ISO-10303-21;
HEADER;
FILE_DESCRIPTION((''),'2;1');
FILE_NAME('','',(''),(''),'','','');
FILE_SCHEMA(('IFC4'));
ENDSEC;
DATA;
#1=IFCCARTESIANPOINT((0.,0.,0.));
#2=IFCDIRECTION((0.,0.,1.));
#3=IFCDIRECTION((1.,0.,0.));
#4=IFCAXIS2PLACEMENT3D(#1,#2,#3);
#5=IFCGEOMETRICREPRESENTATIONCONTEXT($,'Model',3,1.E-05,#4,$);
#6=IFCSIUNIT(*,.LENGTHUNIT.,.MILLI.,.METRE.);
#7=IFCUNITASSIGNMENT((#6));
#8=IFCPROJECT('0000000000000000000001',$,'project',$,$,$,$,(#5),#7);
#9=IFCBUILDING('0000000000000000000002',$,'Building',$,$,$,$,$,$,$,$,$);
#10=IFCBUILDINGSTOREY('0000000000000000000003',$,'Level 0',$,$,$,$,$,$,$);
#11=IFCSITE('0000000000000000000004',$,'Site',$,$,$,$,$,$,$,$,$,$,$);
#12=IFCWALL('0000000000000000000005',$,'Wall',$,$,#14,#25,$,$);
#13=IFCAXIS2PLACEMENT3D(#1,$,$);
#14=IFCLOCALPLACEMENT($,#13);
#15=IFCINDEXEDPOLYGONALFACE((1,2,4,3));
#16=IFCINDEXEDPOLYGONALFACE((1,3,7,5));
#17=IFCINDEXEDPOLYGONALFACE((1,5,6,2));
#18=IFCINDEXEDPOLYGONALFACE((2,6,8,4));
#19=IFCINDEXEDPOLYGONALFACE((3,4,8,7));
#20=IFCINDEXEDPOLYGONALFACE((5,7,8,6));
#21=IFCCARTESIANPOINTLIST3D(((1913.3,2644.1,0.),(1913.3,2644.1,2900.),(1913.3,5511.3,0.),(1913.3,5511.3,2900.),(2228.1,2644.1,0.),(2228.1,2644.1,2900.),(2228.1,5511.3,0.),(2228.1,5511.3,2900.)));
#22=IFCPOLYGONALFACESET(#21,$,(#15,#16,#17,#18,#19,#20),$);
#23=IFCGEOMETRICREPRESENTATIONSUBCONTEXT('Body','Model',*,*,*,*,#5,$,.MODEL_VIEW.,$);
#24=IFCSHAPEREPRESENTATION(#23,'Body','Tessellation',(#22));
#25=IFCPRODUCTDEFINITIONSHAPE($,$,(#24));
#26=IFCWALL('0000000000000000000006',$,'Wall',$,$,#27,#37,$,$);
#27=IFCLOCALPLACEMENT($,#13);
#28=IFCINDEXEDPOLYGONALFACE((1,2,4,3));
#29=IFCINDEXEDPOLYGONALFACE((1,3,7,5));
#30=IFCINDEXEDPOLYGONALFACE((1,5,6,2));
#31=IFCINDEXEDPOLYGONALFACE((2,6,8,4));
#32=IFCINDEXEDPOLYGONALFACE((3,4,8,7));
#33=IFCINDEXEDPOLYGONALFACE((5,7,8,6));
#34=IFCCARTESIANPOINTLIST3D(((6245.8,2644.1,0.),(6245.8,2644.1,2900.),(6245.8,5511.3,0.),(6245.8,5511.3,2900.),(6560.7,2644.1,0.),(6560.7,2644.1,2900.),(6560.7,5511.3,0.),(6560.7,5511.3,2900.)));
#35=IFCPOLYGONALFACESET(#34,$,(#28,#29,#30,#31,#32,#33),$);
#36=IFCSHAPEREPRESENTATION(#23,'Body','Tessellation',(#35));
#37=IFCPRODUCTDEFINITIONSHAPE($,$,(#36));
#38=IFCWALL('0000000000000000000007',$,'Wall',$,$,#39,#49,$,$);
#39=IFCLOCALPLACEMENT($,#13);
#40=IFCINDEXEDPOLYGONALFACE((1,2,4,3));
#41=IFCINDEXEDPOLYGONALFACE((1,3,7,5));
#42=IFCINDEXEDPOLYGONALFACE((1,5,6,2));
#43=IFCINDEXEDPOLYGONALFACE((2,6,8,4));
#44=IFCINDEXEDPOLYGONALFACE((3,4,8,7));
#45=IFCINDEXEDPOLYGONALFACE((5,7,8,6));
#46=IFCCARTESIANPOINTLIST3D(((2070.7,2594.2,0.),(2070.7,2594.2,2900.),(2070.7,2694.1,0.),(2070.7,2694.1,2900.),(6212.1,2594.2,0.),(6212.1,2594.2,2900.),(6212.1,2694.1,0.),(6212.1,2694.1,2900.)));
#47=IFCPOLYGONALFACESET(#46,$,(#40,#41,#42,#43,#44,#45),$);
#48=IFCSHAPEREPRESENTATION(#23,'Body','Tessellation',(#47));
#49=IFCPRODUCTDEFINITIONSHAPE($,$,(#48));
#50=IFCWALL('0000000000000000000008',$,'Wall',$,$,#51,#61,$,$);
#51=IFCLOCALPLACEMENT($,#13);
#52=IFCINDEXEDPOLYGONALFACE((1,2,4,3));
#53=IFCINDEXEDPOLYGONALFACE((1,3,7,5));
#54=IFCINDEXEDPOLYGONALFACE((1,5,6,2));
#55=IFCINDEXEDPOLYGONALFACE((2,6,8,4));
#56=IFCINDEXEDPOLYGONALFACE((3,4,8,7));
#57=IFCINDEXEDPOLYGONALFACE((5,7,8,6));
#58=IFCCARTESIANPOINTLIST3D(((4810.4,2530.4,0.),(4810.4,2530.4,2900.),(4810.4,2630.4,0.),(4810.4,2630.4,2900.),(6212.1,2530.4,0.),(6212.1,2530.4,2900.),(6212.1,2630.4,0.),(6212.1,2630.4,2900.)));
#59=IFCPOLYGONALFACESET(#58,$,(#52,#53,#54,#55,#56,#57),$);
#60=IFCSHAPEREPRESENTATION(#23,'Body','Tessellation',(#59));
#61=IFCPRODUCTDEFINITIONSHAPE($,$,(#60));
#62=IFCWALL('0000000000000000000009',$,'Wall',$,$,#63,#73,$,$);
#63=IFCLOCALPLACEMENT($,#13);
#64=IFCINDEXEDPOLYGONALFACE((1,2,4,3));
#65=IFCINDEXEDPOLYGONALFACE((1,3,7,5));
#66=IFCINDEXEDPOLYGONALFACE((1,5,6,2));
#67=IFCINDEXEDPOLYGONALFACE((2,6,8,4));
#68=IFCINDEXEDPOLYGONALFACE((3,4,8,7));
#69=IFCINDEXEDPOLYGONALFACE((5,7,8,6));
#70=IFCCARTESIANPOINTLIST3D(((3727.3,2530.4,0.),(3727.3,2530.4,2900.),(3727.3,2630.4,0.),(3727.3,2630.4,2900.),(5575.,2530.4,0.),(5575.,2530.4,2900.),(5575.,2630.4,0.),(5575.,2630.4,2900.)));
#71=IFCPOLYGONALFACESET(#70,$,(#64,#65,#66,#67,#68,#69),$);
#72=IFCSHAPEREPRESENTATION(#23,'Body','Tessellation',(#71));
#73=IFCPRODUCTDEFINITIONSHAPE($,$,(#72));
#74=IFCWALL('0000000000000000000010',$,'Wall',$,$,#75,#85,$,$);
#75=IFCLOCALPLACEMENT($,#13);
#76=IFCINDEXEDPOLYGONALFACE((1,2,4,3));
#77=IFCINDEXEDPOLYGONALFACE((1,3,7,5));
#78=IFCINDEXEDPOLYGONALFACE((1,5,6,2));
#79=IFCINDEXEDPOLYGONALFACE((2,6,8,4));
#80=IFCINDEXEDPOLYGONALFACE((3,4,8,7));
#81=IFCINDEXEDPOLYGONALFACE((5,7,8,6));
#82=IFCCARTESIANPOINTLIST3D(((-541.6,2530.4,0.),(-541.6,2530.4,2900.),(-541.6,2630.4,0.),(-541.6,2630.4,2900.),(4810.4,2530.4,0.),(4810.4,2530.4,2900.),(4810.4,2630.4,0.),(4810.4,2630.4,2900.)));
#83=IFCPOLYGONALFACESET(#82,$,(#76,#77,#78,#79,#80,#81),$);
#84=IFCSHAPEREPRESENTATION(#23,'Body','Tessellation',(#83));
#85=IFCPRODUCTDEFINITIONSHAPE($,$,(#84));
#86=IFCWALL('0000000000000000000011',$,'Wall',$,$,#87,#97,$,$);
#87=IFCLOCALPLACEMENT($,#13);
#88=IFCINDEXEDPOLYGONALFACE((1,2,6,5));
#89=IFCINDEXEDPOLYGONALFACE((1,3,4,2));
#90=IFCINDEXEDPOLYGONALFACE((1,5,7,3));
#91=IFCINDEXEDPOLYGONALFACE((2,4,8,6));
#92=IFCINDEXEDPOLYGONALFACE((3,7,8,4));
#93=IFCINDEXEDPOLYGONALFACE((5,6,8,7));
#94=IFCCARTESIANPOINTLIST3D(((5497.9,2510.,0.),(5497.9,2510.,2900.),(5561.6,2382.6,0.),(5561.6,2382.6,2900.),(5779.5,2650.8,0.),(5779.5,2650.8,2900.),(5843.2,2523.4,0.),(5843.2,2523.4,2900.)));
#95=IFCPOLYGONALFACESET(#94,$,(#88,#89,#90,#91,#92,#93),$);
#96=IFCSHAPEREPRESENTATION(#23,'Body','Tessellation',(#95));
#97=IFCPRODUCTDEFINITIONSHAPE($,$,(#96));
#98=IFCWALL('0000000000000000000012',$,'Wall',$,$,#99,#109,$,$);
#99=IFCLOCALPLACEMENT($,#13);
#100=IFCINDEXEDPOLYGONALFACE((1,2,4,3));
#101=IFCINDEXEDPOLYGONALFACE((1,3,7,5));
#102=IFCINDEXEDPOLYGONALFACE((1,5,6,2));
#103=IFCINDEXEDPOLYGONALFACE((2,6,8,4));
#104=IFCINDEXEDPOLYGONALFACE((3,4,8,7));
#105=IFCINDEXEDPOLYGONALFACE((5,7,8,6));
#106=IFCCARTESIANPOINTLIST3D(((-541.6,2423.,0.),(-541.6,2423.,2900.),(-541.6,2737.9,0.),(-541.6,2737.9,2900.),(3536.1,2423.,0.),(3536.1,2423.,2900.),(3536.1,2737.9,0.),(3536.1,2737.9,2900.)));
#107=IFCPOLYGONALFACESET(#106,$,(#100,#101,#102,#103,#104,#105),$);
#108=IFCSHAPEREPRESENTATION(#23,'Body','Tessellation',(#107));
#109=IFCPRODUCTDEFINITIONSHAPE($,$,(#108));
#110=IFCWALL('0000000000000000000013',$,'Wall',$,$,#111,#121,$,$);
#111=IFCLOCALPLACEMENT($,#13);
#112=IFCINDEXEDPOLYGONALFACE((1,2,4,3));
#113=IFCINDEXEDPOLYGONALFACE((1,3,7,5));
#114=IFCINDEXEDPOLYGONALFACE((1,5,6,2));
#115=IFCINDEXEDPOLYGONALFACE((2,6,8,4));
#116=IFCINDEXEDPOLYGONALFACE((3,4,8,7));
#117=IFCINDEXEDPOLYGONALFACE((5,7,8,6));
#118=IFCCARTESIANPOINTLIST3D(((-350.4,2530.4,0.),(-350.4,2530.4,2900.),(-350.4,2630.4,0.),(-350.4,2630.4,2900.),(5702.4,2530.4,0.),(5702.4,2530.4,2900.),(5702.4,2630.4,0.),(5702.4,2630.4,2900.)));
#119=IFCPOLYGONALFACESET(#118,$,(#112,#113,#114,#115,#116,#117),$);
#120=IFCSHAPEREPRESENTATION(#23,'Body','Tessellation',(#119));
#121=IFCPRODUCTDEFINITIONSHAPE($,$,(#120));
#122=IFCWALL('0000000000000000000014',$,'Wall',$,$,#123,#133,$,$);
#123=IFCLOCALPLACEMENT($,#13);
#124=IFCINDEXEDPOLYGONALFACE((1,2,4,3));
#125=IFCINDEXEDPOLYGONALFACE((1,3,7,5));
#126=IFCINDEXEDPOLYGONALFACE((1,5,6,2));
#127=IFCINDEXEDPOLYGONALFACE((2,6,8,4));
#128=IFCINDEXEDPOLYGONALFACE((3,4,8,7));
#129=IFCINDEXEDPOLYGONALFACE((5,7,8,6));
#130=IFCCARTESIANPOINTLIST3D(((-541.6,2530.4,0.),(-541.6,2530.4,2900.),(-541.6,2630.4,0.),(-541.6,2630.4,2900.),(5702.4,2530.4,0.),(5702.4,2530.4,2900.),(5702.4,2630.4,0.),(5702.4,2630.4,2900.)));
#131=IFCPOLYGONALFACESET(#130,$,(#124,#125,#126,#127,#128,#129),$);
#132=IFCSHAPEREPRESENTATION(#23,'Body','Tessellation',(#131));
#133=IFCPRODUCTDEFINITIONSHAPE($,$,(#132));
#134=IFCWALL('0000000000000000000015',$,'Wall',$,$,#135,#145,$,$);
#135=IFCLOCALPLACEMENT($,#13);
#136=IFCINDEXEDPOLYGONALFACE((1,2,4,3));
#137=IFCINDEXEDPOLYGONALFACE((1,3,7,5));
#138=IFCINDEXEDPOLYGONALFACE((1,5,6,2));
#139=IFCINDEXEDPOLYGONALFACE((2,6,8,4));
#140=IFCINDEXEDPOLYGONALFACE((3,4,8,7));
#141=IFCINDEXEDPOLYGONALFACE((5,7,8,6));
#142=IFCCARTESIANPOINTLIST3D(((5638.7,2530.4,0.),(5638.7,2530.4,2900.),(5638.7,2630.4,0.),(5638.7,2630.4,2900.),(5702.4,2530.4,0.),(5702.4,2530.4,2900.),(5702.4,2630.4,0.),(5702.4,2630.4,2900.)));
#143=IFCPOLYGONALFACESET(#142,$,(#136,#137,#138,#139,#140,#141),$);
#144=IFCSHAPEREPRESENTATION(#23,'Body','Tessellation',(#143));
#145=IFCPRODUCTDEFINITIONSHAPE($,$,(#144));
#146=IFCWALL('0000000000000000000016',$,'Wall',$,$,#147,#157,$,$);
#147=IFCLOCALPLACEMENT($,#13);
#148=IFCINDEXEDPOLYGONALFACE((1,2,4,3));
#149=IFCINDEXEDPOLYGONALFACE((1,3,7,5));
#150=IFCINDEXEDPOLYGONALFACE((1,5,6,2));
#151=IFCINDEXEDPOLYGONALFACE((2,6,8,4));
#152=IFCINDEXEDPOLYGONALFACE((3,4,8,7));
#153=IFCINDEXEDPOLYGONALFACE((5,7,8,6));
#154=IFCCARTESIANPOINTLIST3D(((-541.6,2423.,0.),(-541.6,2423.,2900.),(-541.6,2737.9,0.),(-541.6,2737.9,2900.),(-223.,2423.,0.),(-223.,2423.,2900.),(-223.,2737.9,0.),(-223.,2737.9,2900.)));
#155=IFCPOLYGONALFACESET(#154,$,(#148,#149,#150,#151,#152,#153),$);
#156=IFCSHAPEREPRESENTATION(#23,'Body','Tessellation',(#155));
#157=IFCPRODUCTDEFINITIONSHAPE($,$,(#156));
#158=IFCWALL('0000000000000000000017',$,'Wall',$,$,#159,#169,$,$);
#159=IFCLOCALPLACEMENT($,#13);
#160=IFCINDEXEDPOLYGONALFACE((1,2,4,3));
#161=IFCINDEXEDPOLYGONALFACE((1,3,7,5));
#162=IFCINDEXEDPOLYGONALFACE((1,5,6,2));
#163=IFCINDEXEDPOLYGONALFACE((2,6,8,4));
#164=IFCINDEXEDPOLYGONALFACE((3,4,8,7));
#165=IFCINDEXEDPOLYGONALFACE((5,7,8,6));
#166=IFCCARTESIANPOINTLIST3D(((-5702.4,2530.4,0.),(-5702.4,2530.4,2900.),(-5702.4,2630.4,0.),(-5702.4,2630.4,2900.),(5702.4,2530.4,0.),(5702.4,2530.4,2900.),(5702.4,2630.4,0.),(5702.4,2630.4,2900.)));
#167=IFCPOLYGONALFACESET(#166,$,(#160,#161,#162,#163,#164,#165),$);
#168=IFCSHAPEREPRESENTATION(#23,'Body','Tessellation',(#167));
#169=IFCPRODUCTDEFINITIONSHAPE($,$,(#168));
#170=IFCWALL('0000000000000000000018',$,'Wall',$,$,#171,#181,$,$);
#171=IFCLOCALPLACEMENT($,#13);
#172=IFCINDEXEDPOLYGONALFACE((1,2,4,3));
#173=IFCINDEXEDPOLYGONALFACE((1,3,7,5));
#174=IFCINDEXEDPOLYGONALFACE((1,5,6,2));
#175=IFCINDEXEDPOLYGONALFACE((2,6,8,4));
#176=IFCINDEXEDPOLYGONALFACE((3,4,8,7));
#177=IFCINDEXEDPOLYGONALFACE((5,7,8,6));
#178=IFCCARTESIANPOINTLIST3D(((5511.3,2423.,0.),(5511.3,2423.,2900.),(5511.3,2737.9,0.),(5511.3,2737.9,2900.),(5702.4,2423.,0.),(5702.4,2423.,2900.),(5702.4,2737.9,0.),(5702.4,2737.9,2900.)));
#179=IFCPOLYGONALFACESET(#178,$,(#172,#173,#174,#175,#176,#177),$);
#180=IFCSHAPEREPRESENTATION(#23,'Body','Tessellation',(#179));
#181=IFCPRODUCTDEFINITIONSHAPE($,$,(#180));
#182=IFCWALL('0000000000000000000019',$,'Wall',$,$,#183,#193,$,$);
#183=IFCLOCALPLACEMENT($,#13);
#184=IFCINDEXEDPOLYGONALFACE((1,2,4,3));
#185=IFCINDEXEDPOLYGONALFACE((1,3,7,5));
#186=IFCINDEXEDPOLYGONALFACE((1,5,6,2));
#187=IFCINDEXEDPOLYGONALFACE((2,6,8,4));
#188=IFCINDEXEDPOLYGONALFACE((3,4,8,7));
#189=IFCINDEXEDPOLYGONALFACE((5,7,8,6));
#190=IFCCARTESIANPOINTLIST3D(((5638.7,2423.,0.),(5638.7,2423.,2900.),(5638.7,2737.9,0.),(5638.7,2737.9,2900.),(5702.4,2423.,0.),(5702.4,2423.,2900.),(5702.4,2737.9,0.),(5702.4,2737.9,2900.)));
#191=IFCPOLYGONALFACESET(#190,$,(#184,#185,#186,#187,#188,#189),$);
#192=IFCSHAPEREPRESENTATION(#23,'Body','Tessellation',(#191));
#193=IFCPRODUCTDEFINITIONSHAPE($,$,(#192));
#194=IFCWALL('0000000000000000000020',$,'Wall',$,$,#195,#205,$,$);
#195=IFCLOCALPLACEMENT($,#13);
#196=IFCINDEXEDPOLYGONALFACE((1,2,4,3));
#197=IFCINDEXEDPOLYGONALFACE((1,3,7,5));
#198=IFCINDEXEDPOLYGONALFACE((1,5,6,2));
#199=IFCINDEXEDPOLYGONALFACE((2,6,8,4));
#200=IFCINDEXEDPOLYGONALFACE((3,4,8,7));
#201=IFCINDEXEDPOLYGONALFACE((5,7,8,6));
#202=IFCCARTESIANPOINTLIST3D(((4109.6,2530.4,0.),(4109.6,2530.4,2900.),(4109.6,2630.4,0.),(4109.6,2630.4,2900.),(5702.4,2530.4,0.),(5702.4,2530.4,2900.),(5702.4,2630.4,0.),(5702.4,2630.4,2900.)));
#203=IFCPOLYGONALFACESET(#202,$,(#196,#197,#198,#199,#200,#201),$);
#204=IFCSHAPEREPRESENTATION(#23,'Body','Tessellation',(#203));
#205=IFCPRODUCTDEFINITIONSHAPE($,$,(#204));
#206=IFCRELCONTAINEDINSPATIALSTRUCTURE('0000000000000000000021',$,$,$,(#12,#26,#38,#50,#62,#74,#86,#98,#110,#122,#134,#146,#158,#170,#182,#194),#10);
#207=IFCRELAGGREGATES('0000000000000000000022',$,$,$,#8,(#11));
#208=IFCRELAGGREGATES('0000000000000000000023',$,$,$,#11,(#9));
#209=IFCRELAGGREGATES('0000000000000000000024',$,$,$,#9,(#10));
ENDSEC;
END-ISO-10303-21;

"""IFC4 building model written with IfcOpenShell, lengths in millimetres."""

from ifc_helpers import new_model, si_unit, frame, origin_with_axes, place, context, subcontext, project, spatial, indexed_curve, outline, extrude, element, save


model = new_model("IFC4")

# Units and contexts
model_context = context("Model", 3, precision=1e-05, world=origin_with_axes())
body_context = subcontext(model_context, "Body", "Model", "MODEL_VIEW")
ifc_project = project(units=[si_unit("LENGTHUNIT", "METRE", prefix="MILLI")], contexts=[model_context])

# Site, building, storey
site = spatial("IfcSite", under=ifc_project, Name="Site")
building = spatial("IfcBuilding", under=site, Name="Building")
storey = spatial("IfcBuildingStorey", under=building, Name="Level 0")

# Walls
for number, where, z_axis, x_axis, name in (
    (1, (1913.3, 5511.3, 0.0), (0.0, 0.0, 1.0), (0.0, -1.0, 0.0), "Wall"),
    (2, (6245.8, 5511.3, 0.0), (0.0, 0.0, 1.0), (0.0, -1.0, 0.0), "Wall"),
):
    element("IfcWall", number, at=place(None, frame(where, z_axis=z_axis, x_axis=x_axis)), inside=storey, Name=name, context=body_context, shape_type="SweptSolid", body=[
        extrude(outline(indexed_curve([(0.0, 0.0), (0.0, 314.9), (2867.1, 314.9), (2867.1, 0.0), (0.0, 0.0)], self_intersect=False)), origin_with_axes(), (0.0, 0.0, 1.0), 2900.0),
    ])
wall_1_placement = place(None, frame((2070.7, 2594.2, 0.0), z_axis=(0.0, 0.0, 1.0), x_axis=(1.0, 0.0, 0.0)))
element("IfcWall", 3, at=wall_1_placement, inside=storey, Name="Wall", context=body_context, shape_type="SweptSolid", body=[
    extrude(outline(indexed_curve([(0.0, 0.0), (0.0, 99.9), (4141.4, 99.9), (4141.4, 0.0), (0.0, 0.0)], self_intersect=False)), origin_with_axes(), (0.0, 0.0, 1.0), 2900.0),
])
wall_2_placement = place(None, frame((4810.4, 2530.4, 0.0), z_axis=(0.0, 0.0, 1.0), x_axis=(1.0, 0.0, 0.0)))
element("IfcWall", 4, at=wall_2_placement, inside=storey, Name="Wall", context=body_context, shape_type="SweptSolid", body=[
    extrude(outline(indexed_curve([(0.0, 0.0), (0.0, 99.9), (1401.7, 99.9), (1401.7, 0.0), (0.0, 0.0)], self_intersect=False)), origin_with_axes(), (0.0, 0.0, 1.0), 2900.0),
])
wall_3_placement = place(None, frame((3727.3, 2530.4, 0.0), z_axis=(0.0, 0.0, 1.0), x_axis=(1.0, 0.0, 0.0)))
element("IfcWall", 5, at=wall_3_placement, inside=storey, Name="Wall", context=body_context, shape_type="SweptSolid", body=[
    extrude(outline(indexed_curve([(0.0, 0.0), (0.0, 99.9), (1847.7, 99.9), (1847.7, 0.0), (0.0, 0.0)], self_intersect=False)), origin_with_axes(), (0.0, 0.0, 1.0), 2900.0),
])
wall_4_placement = place(None, frame((4810.4, 2630.4, 0.0), z_axis=(0.0, 0.0, 1.0), x_axis=(-1.0, 0.0, 0.0)))
element("IfcWall", 6, at=wall_4_placement, inside=storey, Name="Wall", context=body_context, shape_type="SweptSolid", body=[
    extrude(outline(indexed_curve([(0.0, 0.0), (0.0, 99.9), (5352.0, 99.9), (5352.0, 0.0), (0.0, 0.0)], self_intersect=False)), origin_with_axes(), (0.0, 0.0, 1.0), 2900.0),
])
wall_5_placement = place(None, frame((5843.2, 2523.4, 0.0), z_axis=(0.0, 0.0, 1.0), x_axis=(-0.447214, 0.894427, 0.0)))
element("IfcWall", 7, at=wall_5_placement, inside=storey, Name="Wall", context=body_context, shape_type="SweptSolid", body=[
    extrude(outline(indexed_curve([(0.0, 0.0), (0.0, 314.9), (142.5, 314.9), (142.5, 0.0), (0.0, 0.0)], self_intersect=False)), origin_with_axes(), (0.0, 0.0, 1.0), 2900.0),
])
wall_6_placement = place(None, frame((3536.1, 2737.9, 0.0), z_axis=(0.0, 0.0, 1.0), x_axis=(-1.0, 0.0, 0.0)))
element("IfcWall", 8, at=wall_6_placement, inside=storey, Name="Wall", context=body_context, shape_type="SweptSolid", body=[
    extrude(outline(indexed_curve([(0.0, 0.0), (0.0, 314.9), (4077.7, 314.9), (4077.7, 0.0), (0.0, 0.0)], self_intersect=False)), origin_with_axes(), (0.0, 0.0, 1.0), 2900.0),
])
wall_7_placement = place(None, frame((-350.4, 2530.4, 0.0), z_axis=(0.0, 0.0, 1.0), x_axis=(1.0, 0.0, 0.0)))
element("IfcWall", 9, at=wall_7_placement, inside=storey, Name="Wall", context=body_context, shape_type="SweptSolid", body=[
    extrude(outline(indexed_curve([(0.0, 0.0), (0.0, 99.9), (6052.8, 99.9), (6052.8, 0.0), (0.0, 0.0)], self_intersect=False)), origin_with_axes(), (0.0, 0.0, 1.0), 2900.0),
])
wall_8_placement = place(None, frame((5702.4, 2630.4, 0.0), z_axis=(0.0, 0.0, 1.0), x_axis=(-1.0, 0.0, 0.0)))
element("IfcWall", 10, at=wall_8_placement, inside=storey, Name="Wall", context=body_context, shape_type="SweptSolid", body=[
    extrude(outline(indexed_curve([(0.0, 0.0), (0.0, 99.9), (6244.0, 99.9), (6244.0, 0.0), (0.0, 0.0)], self_intersect=False)), origin_with_axes(), (0.0, 0.0, 1.0), 2900.0),
])
wall_9_placement = place(None, frame((5702.4, 2630.4, 0.0), z_axis=(0.0, 0.0, 1.0), x_axis=(-1.0, 0.0, 0.0)))
element("IfcWall", 11, at=wall_9_placement, inside=storey, Name="Wall", context=body_context, shape_type="SweptSolid", body=[
    extrude(outline(indexed_curve([(0.0, 0.0), (0.0, 99.9), (63.7, 99.9), (63.7, 0.0), (0.0, 0.0)], self_intersect=False)), origin_with_axes(), (0.0, 0.0, 1.0), 2900.0),
])
wall_10_placement = place(None, frame((-223.0, 2737.9, 0.0), z_axis=(0.0, 0.0, 1.0), x_axis=(-1.0, 0.0, 0.0)))
element("IfcWall", 12, at=wall_10_placement, inside=storey, Name="Wall", context=body_context, shape_type="SweptSolid", body=[
    extrude(outline(indexed_curve([(0.0, 0.0), (0.0, 314.9), (318.6, 314.9), (318.6, 0.0), (0.0, 0.0)], self_intersect=False)), origin_with_axes(), (0.0, 0.0, 1.0), 2900.0),
])
wall_11_placement = place(None, frame((5702.4, 2630.4, 0.0), z_axis=(0.0, 0.0, 1.0), x_axis=(-1.0, 0.0, 0.0)))
element("IfcWall", 13, at=wall_11_placement, inside=storey, Name="Wall", context=body_context, shape_type="SweptSolid", body=[
    extrude(outline(indexed_curve([(0.0, 0.0), (0.0, 99.9), (11404.8, 99.9), (11404.8, 0.0), (0.0, 0.0)], self_intersect=False)), origin_with_axes(), (0.0, 0.0, 1.0), 2900.0),
])
wall_12_placement = place(None, frame((5702.4, 2737.9, 0.0), z_axis=(0.0, 0.0, 1.0), x_axis=(-1.0, 0.0, 0.0)))
element("IfcWall", 14, at=wall_12_placement, inside=storey, Name="Wall", context=body_context, shape_type="SweptSolid", body=[
    extrude(outline(indexed_curve([(0.0, 0.0), (0.0, 314.9), (191.1, 314.9), (191.1, 0.0), (0.0, 0.0)], self_intersect=False)), origin_with_axes(), (0.0, 0.0, 1.0), 2900.0),
])
wall_13_placement = place(None, frame((5702.4, 2737.9, 0.0), z_axis=(0.0, 0.0, 1.0), x_axis=(-1.0, 0.0, 0.0)))
element("IfcWall", 15, at=wall_13_placement, inside=storey, Name="Wall", context=body_context, shape_type="SweptSolid", body=[
    extrude(outline(indexed_curve([(0.0, 0.0), (0.0, 314.9), (63.7, 314.9), (63.7, 0.0), (0.0, 0.0)], self_intersect=False)), origin_with_axes(), (0.0, 0.0, 1.0), 2900.0),
])
wall_14_placement = place(None, frame((4109.6, 2530.4, 0.0), z_axis=(0.0, 0.0, 1.0), x_axis=(1.0, 0.0, 0.0)))
element("IfcWall", 16, at=wall_14_placement, inside=storey, Name="Wall", context=body_context, shape_type="SweptSolid", body=[
    extrude(outline(indexed_curve([(0.0, 0.0), (0.0, 99.9), (1592.9, 99.9), (1592.9, 0.0), (0.0, 0.0)], self_intersect=False)), origin_with_axes(), (0.0, 0.0, 1.0), 2900.0),
])

save(model, "model.ifc")
